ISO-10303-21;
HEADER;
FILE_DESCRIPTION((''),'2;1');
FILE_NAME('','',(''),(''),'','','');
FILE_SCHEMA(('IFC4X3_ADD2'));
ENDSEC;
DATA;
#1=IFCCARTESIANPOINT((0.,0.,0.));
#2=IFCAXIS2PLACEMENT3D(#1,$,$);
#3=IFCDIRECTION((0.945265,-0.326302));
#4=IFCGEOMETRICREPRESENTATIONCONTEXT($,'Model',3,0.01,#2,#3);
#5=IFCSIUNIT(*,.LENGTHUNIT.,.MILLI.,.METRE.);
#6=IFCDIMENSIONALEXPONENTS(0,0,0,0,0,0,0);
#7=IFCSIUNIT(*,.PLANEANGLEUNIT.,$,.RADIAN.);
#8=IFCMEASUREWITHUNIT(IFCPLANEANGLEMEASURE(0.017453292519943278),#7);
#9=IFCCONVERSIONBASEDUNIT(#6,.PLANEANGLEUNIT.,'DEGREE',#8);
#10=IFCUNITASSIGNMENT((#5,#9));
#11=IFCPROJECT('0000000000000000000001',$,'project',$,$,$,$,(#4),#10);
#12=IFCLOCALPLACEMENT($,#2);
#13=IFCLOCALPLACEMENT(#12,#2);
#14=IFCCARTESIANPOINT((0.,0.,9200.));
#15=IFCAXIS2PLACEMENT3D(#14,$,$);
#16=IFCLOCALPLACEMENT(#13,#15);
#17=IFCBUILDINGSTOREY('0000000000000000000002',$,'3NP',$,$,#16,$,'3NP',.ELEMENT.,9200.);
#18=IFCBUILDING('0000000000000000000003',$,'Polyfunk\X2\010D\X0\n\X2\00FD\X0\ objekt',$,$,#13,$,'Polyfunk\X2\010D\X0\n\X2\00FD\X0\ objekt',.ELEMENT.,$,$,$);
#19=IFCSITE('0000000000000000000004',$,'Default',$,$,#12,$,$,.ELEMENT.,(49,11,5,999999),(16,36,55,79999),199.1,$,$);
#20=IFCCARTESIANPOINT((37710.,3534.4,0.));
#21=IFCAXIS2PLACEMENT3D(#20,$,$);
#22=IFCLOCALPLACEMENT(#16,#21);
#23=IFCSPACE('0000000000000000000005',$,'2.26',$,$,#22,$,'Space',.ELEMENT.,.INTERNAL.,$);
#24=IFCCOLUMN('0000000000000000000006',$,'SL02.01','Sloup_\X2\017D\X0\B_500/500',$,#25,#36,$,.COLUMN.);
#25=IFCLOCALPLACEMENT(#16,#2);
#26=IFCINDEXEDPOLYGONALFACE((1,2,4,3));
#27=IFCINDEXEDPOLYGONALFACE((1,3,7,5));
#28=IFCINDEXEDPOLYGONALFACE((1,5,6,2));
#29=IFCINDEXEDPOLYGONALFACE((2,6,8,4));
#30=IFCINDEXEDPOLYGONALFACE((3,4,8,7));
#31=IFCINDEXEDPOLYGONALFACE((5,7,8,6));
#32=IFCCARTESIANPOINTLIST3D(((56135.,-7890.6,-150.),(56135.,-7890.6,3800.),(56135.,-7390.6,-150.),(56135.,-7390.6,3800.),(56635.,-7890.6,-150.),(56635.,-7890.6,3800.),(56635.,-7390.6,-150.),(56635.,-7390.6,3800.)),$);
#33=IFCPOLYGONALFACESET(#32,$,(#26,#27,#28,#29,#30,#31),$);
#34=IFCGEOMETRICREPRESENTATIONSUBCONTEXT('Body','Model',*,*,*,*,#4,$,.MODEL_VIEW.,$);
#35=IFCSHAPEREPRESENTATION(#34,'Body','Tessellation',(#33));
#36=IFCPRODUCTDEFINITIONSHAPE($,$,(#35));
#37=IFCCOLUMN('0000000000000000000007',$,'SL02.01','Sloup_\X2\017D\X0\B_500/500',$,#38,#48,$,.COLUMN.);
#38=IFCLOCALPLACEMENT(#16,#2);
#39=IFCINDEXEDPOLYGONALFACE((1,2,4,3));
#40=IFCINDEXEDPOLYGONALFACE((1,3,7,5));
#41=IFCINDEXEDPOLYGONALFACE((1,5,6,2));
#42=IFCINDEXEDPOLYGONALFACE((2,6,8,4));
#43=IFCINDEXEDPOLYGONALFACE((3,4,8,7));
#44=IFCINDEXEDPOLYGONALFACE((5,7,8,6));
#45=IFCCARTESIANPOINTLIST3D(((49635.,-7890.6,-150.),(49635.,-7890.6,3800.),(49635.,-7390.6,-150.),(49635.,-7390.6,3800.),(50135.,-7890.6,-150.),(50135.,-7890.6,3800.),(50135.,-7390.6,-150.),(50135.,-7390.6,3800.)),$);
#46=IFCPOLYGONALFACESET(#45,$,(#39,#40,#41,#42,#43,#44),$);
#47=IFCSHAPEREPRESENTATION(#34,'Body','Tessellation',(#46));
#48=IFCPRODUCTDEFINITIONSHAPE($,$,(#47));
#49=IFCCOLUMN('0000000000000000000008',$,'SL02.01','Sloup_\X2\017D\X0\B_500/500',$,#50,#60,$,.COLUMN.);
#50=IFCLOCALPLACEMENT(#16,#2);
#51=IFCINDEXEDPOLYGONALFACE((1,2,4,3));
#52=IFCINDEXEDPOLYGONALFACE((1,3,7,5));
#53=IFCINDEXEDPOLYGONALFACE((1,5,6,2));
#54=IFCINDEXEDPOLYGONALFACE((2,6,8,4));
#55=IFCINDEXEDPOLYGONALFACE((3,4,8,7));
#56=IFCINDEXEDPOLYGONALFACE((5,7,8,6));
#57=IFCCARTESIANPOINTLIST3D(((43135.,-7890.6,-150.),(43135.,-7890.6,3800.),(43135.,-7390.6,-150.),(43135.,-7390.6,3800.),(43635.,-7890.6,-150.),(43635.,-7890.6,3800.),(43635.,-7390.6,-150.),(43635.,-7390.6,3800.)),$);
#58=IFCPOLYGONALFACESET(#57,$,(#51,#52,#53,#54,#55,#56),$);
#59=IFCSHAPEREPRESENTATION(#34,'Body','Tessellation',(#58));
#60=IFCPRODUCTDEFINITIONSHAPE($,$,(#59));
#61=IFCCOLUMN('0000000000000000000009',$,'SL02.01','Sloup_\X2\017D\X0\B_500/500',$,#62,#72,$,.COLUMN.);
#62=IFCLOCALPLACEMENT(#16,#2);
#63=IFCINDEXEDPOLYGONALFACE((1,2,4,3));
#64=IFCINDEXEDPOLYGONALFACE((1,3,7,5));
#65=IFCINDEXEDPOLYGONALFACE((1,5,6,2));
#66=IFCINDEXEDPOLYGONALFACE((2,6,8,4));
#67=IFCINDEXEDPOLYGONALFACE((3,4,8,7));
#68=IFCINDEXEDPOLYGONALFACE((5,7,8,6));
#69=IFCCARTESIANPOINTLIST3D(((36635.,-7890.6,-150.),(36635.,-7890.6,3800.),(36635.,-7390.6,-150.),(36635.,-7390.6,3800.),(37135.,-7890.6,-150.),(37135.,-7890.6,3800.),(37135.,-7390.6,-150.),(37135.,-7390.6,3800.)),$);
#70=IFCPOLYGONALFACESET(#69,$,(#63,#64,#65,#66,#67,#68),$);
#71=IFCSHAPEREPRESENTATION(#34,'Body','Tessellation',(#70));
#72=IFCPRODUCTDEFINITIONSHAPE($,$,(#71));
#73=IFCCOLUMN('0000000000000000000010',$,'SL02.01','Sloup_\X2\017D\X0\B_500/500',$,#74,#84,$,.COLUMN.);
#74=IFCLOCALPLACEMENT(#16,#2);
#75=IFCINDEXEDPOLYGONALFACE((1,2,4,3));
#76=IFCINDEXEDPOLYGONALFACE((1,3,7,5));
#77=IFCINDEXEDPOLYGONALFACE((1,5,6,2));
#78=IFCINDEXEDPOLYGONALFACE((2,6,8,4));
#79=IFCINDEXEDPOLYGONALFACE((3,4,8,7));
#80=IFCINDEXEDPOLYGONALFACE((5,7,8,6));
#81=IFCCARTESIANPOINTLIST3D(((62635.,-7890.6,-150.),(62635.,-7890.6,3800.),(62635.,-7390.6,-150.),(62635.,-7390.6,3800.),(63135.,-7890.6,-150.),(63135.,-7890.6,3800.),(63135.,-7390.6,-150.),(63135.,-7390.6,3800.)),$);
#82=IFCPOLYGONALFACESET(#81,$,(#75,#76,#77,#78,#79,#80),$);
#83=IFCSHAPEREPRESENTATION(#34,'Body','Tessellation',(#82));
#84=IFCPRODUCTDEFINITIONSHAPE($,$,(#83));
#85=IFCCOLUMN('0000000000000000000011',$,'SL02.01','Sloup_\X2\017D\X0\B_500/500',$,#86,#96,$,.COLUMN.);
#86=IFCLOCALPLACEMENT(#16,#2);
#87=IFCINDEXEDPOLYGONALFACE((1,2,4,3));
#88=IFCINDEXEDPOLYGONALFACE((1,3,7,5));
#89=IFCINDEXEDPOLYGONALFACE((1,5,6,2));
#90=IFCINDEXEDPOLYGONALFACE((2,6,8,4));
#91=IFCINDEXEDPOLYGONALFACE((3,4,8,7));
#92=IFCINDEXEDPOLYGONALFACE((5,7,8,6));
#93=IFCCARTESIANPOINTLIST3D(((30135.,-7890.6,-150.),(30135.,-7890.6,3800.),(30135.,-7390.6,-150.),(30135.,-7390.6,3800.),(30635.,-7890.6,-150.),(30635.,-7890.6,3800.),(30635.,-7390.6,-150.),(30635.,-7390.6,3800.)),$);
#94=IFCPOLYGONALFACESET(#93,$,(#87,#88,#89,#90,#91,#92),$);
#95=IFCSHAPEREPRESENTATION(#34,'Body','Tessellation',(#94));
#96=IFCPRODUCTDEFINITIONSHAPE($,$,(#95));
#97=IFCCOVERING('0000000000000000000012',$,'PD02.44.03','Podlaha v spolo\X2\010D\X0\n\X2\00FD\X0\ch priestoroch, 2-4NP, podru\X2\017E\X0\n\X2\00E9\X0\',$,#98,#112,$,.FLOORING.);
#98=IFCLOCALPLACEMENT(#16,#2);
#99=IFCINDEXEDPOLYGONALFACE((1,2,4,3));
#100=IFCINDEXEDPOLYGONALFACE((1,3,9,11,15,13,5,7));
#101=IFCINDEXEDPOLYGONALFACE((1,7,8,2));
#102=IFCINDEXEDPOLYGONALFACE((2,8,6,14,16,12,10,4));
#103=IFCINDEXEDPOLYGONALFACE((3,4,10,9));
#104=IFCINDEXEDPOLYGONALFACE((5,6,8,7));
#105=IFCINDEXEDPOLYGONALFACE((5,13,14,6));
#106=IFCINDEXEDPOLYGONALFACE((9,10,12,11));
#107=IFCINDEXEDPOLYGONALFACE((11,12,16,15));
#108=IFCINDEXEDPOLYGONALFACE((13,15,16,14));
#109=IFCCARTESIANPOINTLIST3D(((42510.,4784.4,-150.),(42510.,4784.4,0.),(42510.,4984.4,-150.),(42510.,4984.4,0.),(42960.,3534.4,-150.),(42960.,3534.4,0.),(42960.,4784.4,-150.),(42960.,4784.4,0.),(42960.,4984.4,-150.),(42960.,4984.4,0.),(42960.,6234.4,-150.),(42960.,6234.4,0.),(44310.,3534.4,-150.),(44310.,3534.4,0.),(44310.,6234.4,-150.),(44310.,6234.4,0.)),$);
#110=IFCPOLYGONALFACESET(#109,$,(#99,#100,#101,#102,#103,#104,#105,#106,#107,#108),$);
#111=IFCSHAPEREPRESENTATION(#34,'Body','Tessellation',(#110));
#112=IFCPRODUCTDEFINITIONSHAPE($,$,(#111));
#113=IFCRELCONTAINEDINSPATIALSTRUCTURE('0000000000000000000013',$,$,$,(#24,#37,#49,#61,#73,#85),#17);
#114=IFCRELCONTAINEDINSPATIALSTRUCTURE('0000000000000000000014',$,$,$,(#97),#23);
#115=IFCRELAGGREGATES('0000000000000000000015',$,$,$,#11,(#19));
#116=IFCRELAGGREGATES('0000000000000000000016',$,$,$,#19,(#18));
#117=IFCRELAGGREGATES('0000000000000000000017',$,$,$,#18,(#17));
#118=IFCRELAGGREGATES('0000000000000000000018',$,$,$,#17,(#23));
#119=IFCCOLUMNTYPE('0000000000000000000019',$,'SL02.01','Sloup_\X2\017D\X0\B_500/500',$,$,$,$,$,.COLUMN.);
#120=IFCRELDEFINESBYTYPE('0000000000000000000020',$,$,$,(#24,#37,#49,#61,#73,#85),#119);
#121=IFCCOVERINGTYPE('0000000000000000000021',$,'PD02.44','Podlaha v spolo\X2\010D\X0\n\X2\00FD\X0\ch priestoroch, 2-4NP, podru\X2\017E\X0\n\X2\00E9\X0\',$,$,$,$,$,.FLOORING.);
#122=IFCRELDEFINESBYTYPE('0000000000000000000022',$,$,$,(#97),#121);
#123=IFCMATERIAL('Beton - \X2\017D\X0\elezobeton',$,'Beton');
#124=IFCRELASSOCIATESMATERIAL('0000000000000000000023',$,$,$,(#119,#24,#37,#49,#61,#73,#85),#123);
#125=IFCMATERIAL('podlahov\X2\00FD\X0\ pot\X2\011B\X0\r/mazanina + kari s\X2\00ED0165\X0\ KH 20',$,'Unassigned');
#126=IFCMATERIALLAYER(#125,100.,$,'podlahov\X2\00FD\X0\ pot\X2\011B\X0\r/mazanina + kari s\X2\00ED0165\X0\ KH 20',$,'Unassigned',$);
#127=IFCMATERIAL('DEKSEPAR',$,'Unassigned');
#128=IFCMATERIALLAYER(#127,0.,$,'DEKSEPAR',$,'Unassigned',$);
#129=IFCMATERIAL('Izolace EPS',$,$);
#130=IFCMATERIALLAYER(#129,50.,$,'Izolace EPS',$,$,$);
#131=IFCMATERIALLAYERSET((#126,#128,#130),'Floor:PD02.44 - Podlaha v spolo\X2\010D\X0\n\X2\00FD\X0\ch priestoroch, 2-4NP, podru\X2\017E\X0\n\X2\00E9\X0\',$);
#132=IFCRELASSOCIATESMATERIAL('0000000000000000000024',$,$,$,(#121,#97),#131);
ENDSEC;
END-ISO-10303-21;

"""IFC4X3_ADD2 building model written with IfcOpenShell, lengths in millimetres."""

from ifc_helpers import new_model, entity, si_unit, converted_unit, direction, frame, frame_2d, origin, origin_2d_with_axis, place, context, subcontext, project, spatial, polyline, rectangle, outline, extrude, source, transform, mapped, material, layer, layer_set, layer_usage, material_profile, profile_set, profile_usage, type_object, element, save


model = new_model("IFC4X3_ADD2")

# Units and contexts
model_context = context("Model", 3, precision=0.01, world=origin(), true_north=direction((0.945265, -0.326302)))
body_context = subcontext(model_context, "Body", "Model", "MODEL_VIEW")
ifc_project = project(units=[si_unit("LENGTHUNIT", "METRE", prefix="MILLI"), converted_unit("PLANEANGLEUNIT", "DEGREE", entity("IfcPlaneAngleMeasure", 0.017453292519943278), si_unit("PLANEANGLEUNIT", "RADIAN"), dimensions=[0, 0, 0, 0, 0, 0, 0])], contexts=[model_context])

# Site, building, storey
site_placement = place(None, origin())
site = spatial("IfcSite", under=ifc_project, at=site_placement, Name="Default", CompositionType="ELEMENT", RefLatitude=(49, 11, 5, 999999), RefLongitude=(16, 36, 55, 79999), RefElevation=199.1)
building_placement = place(site_placement, origin())
building = spatial("IfcBuilding", under=site, at=building_placement, Name="Polyfunkčný objekt", LongName="Polyfunkčný objekt", CompositionType="ELEMENT")
storey_placement = place(building_placement, frame((0.0, 0.0, 9200.0)))
storey = spatial("IfcBuildingStorey", under=building, at=storey_placement, Name="3NP", LongName="3NP", CompositionType="ELEMENT", Elevation=9200.0)

# Columns
ifc_material_1 = material(Name="Beton - Železobeton", Category="Beton")
ifc_material_profile_1 = material_profile(ifc_material_1, rectangle(XDim=500.0, YDim=500.0, at=frame_2d((0.0, 0.0), x_axis=(1.0, 0.0))), Name="Sloup_ŽB_500/500")
ifc_profile_set_1 = profile_set([ifc_material_profile_1], Name="Sloup_ŽB_500/500")
ifc_profile_usage_1 = profile_usage(ifc_profile_set_1)
column_type_1 = type_object("IfcColumnType", Name="SL02.01", Description="Sloup_ŽB_500/500", PredefinedType="COLUMN", material=ifc_profile_set_1)
shared_shape_1 = source(origin(), body_context, "Body", "SweptSolid", [
    extrude(rectangle(XDim=500.0, YDim=500.0, at=origin_2d_with_axis()), frame((56385.0, -7640.6, 9050.0)), (0.0, 0.0, 1.0), 3950.0),
])
column_1_placement = place(storey_placement, frame((0.0, 0.0, -9200.0)))
element("IfcColumn", 1, at=column_1_placement, inside=storey, type_object=column_type_1, material=ifc_profile_usage_1, Name="SL02.01", Description="Sloup_ŽB_500/500", PredefinedType="COLUMN", context=body_context, shape_type="MappedRepresentation", body=[
    mapped(shared_shape_1, transform((0.0, 0.0, 0.0), scale=1.0)),
])
shared_shape_2 = source(origin(), body_context, "Body", "SweptSolid", [
    extrude(rectangle(XDim=500.0, YDim=500.0, at=frame_2d((0.0, 0.0), x_axis=(1.0, 0.0))), frame((49885.0, -7640.6, 9050.0)), (0.0, 0.0, 1.0), 3950.0),
])
column_2_placement = place(storey_placement, frame((0.0, 0.0, -9200.0)))
element("IfcColumn", 2, at=column_2_placement, inside=storey, type_object=column_type_1, material=ifc_profile_usage_1, Name="SL02.01", Description="Sloup_ŽB_500/500", PredefinedType="COLUMN", context=body_context, shape_type="MappedRepresentation", body=[
    mapped(shared_shape_2, transform((0.0, 0.0, 0.0), scale=1.0)),
])
shared_shape_3 = source(origin(), body_context, "Body", "SweptSolid", [
    extrude(rectangle(XDim=500.0, YDim=500.0, at=origin_2d_with_axis()), frame((43385.0, -7640.6, 9050.0)), (0.0, 0.0, 1.0), 3950.0),
])
column_3_placement = place(storey_placement, frame((0.0, 0.0, -9200.0)))
element("IfcColumn", 3, at=column_3_placement, inside=storey, type_object=column_type_1, material=ifc_profile_usage_1, Name="SL02.01", Description="Sloup_ŽB_500/500", PredefinedType="COLUMN", context=body_context, shape_type="MappedRepresentation", body=[
    mapped(shared_shape_3, transform((0.0, 0.0, 0.0), scale=1.0)),
])
shared_shape_4 = source(origin(), body_context, "Body", "SweptSolid", [
    extrude(rectangle(XDim=500.0, YDim=500.0, at=origin_2d_with_axis()), frame((36885.0, -7640.6, 9050.0)), (0.0, 0.0, 1.0), 3950.0),
])
column_4_placement = place(storey_placement, frame((0.0, 0.0, -9200.0)))
element("IfcColumn", 4, at=column_4_placement, inside=storey, type_object=column_type_1, material=ifc_profile_usage_1, Name="SL02.01", Description="Sloup_ŽB_500/500", PredefinedType="COLUMN", context=body_context, shape_type="MappedRepresentation", body=[
    mapped(shared_shape_4, transform((0.0, 0.0, 0.0), scale=1.0)),
])
shared_shape_5 = source(origin(), body_context, "Body", "SweptSolid", [
    extrude(rectangle(XDim=500.0, YDim=500.0, at=frame_2d((0.0, 0.0), x_axis=(1.0, 0.0))), frame((62885.0, -7640.6, 9050.0), z_axis=(0.0, 0.0, 1.0), x_axis=(-1.0, 0.0, 0.0)), (0.0, 0.0, 1.0), 3950.0),
])
column_5_placement = place(storey_placement, frame((0.0, 0.0, -9200.0)))
element("IfcColumn", 5, at=column_5_placement, inside=storey, type_object=column_type_1, material=ifc_profile_usage_1, Name="SL02.01", Description="Sloup_ŽB_500/500", PredefinedType="COLUMN", context=body_context, shape_type="MappedRepresentation", body=[
    mapped(shared_shape_5, transform((0.0, 0.0, 0.0), scale=1.0)),
])
shared_shape_6 = source(origin(), body_context, "Body", "SweptSolid", [
    extrude(rectangle(XDim=500.0, YDim=500.0, at=frame_2d((0.0, 0.0), x_axis=(1.0, 0.0))), frame((30385.0, -7640.6, 9050.0), z_axis=(0.0, 0.0, 1.0), x_axis=(-1.0, 0.0, 0.0)), (0.0, 0.0, 1.0), 3950.0),
])
column_6_placement = place(storey_placement, frame((0.0, 0.0, -9200.0)))
element("IfcColumn", 6, at=column_6_placement, inside=storey, type_object=column_type_1, material=ifc_profile_usage_1, Name="SL02.01", Description="Sloup_ŽB_500/500", PredefinedType="COLUMN", context=body_context, shape_type="MappedRepresentation", body=[
    mapped(shared_shape_6, transform((0.0, 0.0, 0.0), scale=1.0)),
])

# Shared definitions
space_1_placement = place(storey_placement, frame((37710.0, 3534.4, 0.0)))
space_1 = spatial("IfcSpace", under=storey, at=space_1_placement, Name="2.26", LongName="Space", CompositionType="ELEMENT", PredefinedType="INTERNAL")

# Covering
ifc_material_2 = material(Name="podlahový potěr/mazanina + kari síť KH 20", Category="Unassigned")
ifc_layer_1 = layer(ifc_material_2, 100.0, Name="podlahový potěr/mazanina + kari síť KH 20", Category="Unassigned")
ifc_material_3 = material(Name="DEKSEPAR", Category="Unassigned")
ifc_layer_2 = layer(ifc_material_3, 0.0, Name="DEKSEPAR", Category="Unassigned")
ifc_material_4 = material(Name="Izolace EPS")
ifc_layer_3 = layer(ifc_material_4, 50.0, Name="Izolace EPS")
ifc_layer_set_1 = layer_set([ifc_layer_1, ifc_layer_2, ifc_layer_3], Name="Floor:PD02.44 - Podlaha v spoločných priestoroch, 2-4NP, podružné")
ifc_layer_usage_1 = layer_usage(ifc_layer_set_1, "AXIS3", "POSITIVE", 0.0)
covering_type_1 = type_object("IfcCoveringType", Name="PD02.44", Description="Podlaha v spoločných priestoroch, 2-4NP, podružné", PredefinedType="FLOORING", material=ifc_layer_set_1)
covering_1_placement = place(storey_placement, origin())
element("IfcCovering", 7, at=covering_1_placement, inside=space_1, type_object=covering_type_1, material=ifc_layer_usage_1, Name="PD02.44.03", Description="Podlaha v spoločných priestoroch, 2-4NP, podružné", PredefinedType="FLOORING", context=body_context, shape_type="SweptSolid", body=[
    extrude(outline(polyline([(-100.0, -675.0), (100.0, -675.0), (100.0, -225.0), (1350.0, -225.0), (1350.0, 1125.0), (-1350.0, 1125.0), (-1350.0, -225.0), (-100.0, -225.0), (-100.0, -675.0)])), frame((43185.0, 4884.4, 0.0), z_axis=(0.0, 0.0, -1.0), x_axis=(0.0, 1.0, 0.0)), (0.0, 0.0, 1.0), 150.0),
])

save(model, "model.ifc")
